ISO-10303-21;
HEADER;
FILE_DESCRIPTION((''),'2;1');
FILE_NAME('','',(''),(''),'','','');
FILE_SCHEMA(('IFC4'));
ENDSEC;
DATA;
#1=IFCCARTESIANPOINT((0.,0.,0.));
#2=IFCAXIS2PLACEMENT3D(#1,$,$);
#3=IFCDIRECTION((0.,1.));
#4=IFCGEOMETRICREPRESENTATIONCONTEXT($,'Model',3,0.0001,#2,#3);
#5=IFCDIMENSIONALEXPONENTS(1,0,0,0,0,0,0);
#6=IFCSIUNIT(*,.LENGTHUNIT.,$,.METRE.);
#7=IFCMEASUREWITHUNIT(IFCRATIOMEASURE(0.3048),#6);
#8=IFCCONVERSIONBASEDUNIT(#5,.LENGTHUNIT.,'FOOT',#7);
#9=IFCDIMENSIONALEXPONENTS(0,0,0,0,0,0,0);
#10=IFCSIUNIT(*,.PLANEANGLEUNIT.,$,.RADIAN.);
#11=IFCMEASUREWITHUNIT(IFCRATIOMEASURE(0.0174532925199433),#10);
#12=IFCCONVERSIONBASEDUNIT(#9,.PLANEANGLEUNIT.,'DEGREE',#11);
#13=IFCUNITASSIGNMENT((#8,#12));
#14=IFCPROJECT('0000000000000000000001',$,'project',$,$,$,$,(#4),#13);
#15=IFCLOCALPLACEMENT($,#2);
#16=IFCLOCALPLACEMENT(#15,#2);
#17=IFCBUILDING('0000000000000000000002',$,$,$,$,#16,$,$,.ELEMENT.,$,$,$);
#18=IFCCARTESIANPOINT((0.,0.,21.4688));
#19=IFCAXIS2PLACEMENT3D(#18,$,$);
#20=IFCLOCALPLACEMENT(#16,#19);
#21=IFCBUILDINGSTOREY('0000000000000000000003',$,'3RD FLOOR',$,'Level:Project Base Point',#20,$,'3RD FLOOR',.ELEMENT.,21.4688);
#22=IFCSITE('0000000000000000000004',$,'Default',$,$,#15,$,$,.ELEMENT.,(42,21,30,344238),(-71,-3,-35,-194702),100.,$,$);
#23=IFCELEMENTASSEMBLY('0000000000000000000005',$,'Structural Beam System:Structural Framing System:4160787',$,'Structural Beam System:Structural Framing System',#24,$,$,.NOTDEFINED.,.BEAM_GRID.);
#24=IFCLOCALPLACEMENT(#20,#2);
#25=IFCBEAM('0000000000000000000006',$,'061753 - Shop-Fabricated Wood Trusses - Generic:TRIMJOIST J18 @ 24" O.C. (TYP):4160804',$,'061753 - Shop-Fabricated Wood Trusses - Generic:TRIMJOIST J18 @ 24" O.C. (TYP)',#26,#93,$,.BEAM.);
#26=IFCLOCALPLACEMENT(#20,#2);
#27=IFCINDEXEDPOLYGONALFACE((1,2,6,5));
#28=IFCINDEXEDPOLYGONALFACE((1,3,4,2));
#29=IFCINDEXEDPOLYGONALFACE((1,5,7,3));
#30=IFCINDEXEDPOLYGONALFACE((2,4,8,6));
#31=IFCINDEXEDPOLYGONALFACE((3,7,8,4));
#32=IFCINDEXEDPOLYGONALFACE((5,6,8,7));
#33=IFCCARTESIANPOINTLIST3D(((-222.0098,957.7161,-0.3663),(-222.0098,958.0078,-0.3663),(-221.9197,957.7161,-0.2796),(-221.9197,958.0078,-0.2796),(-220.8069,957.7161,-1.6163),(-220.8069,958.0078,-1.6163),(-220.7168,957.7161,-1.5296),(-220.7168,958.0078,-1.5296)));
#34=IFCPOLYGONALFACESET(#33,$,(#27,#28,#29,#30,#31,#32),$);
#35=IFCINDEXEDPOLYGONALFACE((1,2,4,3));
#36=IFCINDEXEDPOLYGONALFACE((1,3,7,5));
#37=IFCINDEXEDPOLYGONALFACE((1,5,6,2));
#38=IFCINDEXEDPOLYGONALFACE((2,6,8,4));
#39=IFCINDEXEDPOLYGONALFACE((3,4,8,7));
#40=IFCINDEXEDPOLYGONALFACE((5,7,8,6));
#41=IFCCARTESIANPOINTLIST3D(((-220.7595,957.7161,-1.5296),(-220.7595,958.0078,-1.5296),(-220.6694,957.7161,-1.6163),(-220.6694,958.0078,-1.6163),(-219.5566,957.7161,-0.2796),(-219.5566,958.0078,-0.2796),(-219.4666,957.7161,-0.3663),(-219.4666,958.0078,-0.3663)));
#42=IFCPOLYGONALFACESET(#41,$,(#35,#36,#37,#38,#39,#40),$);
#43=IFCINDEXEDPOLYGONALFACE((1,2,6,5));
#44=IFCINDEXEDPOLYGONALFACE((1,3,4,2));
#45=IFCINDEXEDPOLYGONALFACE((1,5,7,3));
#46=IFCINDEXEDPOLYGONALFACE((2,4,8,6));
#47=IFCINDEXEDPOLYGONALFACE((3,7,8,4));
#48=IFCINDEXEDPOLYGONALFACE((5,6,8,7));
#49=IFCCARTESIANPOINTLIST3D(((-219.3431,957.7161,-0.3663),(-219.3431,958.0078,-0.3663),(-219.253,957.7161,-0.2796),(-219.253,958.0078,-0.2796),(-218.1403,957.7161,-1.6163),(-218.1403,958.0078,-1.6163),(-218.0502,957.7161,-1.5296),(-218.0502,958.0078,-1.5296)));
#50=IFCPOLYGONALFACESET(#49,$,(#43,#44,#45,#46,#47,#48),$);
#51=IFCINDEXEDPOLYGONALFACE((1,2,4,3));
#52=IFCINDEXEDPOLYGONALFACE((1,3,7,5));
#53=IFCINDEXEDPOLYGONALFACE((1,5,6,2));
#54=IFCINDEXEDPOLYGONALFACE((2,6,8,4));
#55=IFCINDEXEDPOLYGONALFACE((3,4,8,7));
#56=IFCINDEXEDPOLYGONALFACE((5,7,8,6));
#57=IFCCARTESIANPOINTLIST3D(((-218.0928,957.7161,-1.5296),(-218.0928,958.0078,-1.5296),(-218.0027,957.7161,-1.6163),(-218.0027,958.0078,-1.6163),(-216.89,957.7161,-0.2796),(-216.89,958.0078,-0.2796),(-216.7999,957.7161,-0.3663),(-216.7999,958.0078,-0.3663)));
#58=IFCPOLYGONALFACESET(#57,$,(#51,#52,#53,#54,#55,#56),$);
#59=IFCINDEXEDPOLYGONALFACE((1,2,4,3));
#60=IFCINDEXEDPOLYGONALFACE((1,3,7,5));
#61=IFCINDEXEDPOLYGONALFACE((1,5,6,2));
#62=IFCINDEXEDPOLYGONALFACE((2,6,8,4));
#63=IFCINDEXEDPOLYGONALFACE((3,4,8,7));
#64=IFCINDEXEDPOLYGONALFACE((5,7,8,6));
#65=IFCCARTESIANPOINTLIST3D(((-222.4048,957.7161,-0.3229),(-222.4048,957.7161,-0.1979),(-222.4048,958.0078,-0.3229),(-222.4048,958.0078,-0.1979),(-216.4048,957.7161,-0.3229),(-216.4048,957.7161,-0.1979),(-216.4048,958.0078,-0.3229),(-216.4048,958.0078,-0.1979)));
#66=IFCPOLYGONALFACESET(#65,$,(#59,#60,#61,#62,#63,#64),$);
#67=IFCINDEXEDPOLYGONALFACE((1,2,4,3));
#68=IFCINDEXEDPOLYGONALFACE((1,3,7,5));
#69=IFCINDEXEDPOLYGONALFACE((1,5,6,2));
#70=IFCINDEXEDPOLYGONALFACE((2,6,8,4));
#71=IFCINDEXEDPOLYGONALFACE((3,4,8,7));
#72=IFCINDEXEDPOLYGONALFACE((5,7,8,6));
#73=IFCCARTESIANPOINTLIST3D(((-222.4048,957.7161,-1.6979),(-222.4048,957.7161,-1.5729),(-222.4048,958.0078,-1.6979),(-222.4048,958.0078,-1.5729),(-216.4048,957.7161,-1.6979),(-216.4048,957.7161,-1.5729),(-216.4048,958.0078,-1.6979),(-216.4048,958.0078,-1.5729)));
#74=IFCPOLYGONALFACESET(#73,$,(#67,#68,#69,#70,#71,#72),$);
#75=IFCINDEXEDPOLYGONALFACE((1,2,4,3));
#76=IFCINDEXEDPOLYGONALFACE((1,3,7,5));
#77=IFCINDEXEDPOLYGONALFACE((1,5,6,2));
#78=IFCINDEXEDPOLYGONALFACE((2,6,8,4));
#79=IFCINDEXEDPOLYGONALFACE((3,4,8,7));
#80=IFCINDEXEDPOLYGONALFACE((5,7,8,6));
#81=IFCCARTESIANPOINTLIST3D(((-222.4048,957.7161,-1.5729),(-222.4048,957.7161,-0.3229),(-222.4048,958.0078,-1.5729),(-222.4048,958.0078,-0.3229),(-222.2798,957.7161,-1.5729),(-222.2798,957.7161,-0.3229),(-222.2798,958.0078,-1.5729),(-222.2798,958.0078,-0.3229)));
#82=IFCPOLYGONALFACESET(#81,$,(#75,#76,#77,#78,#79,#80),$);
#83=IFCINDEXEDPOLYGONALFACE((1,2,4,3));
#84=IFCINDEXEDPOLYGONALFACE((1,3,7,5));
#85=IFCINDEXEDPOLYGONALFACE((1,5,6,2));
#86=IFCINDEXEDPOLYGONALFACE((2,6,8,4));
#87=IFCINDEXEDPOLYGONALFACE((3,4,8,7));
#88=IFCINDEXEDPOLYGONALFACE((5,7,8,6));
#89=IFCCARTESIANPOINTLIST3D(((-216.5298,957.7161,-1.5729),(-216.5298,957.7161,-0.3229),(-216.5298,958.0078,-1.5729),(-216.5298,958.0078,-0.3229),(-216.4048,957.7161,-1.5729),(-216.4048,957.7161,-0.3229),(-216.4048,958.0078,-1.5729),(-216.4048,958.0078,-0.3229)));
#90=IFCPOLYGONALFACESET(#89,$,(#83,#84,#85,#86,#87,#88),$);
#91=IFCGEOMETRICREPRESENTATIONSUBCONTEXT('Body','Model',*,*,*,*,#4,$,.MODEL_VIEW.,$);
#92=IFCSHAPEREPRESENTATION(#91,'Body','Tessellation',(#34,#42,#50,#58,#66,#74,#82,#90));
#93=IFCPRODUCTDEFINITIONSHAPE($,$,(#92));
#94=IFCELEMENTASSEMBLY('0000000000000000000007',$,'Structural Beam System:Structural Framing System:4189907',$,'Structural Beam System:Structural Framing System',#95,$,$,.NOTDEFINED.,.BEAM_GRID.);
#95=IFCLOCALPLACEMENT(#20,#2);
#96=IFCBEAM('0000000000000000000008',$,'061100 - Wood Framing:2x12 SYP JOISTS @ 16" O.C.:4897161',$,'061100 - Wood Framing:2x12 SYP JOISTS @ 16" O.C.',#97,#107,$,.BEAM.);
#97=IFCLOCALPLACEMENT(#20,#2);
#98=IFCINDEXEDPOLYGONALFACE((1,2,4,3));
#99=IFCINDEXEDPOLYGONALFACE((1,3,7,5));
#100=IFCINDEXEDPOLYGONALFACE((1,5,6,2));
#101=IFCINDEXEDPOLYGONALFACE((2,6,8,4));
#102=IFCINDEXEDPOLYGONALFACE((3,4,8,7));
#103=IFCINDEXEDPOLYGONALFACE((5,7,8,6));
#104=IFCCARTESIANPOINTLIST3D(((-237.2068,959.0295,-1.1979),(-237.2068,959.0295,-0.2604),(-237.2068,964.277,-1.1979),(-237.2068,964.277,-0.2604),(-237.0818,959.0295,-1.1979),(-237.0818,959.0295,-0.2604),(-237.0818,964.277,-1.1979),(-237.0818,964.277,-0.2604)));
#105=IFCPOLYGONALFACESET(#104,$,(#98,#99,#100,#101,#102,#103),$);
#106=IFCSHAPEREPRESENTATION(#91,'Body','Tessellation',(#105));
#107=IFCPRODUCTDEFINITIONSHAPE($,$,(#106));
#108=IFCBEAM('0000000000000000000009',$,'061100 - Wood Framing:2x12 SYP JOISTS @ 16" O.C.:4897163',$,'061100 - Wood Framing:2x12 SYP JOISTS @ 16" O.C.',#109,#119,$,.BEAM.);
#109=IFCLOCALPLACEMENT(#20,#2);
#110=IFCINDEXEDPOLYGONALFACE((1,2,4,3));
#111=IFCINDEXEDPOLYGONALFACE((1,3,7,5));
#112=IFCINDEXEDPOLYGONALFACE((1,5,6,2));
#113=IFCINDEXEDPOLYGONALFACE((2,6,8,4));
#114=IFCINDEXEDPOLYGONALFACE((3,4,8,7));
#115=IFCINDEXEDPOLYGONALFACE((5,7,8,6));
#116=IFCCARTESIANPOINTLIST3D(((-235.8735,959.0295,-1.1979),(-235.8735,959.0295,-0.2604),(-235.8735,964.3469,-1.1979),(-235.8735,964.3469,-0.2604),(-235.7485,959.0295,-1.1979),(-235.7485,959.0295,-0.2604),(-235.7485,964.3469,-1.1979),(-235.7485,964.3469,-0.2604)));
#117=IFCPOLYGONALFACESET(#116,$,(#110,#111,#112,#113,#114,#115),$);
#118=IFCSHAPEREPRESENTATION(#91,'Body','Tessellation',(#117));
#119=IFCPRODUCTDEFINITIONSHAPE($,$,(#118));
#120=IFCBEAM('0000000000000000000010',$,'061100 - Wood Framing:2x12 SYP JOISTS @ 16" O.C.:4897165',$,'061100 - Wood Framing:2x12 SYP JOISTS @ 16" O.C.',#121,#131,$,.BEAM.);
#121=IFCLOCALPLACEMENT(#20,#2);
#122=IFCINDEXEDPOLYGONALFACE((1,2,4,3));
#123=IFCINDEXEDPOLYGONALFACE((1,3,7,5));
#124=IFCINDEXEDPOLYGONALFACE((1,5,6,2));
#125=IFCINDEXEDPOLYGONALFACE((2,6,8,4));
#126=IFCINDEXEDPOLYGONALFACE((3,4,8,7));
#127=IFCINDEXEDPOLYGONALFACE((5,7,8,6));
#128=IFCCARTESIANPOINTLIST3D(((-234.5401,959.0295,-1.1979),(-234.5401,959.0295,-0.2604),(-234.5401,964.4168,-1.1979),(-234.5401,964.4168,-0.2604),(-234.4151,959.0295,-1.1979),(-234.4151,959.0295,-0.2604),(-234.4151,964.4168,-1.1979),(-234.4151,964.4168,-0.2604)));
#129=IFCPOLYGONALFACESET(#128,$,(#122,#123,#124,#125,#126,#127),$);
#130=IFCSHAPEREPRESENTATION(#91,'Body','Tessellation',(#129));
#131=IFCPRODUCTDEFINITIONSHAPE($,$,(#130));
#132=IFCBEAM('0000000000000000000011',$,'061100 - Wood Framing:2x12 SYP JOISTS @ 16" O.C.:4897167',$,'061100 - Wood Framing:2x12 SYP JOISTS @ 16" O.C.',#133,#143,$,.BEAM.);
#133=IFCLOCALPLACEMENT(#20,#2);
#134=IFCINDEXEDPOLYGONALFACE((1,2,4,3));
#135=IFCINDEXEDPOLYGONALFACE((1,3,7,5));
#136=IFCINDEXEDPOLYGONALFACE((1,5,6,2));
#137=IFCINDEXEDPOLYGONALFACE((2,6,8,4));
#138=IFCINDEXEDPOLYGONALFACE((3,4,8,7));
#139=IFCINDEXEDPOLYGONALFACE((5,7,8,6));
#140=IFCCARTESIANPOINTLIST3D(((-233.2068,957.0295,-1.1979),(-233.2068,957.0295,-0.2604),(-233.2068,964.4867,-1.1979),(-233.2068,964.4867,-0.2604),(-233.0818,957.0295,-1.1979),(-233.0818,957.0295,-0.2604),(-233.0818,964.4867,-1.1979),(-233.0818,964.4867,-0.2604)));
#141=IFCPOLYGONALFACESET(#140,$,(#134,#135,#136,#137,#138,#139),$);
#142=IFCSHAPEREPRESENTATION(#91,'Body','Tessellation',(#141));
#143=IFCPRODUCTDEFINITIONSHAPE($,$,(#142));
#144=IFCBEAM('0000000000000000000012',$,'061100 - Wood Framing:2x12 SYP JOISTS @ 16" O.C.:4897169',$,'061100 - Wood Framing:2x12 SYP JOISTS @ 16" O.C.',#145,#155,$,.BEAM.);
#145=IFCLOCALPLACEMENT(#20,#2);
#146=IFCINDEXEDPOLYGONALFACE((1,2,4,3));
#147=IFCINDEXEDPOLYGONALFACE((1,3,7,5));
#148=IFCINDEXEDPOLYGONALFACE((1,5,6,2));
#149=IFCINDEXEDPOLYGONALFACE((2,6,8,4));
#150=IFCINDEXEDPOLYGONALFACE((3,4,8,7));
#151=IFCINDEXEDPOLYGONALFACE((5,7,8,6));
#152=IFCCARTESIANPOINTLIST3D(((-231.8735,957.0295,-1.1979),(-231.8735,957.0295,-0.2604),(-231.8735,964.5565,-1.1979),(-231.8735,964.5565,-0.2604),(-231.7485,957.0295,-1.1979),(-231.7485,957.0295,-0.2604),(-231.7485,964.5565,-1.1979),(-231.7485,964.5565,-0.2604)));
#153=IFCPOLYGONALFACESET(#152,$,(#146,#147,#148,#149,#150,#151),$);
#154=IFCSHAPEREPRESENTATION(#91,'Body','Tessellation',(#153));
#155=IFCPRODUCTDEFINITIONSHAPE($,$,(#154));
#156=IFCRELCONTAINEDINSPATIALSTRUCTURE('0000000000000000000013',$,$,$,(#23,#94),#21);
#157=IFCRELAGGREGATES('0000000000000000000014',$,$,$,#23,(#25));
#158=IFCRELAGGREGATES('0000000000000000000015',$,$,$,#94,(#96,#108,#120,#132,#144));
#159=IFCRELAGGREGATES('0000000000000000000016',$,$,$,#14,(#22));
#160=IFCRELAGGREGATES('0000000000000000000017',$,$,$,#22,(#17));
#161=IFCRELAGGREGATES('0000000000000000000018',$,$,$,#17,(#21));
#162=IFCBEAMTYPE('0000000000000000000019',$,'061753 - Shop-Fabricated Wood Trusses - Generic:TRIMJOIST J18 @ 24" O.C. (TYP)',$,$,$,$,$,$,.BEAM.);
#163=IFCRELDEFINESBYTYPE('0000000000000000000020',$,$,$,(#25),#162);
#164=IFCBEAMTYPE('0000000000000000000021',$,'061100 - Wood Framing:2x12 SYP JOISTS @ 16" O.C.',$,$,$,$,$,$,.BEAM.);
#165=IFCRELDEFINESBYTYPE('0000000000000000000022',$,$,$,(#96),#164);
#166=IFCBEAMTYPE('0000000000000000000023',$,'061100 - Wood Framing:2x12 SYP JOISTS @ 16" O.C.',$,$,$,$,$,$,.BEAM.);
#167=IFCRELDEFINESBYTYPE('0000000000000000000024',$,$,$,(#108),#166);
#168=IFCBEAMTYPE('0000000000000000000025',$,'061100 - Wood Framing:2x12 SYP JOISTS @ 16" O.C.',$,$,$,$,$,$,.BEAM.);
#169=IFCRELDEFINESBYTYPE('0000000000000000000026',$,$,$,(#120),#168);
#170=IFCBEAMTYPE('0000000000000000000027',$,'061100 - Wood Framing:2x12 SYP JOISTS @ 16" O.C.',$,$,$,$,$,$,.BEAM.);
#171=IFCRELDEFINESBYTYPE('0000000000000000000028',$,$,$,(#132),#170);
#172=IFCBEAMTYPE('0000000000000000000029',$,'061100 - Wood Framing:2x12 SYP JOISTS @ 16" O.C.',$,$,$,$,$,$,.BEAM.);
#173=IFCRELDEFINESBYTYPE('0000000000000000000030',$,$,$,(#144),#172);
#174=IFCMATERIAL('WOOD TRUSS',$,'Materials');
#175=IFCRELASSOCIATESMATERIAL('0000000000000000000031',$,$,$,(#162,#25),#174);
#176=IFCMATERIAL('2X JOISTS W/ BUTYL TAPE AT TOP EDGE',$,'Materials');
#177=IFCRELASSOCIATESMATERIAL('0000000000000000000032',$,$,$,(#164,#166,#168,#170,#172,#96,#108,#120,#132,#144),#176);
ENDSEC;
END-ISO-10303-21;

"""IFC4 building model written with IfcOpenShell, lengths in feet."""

from ifc_helpers import new_model, entity, si_unit, converted_unit, direction, frame, frame_2d, origin, origin_2d_with_axis, place, context, subcontext, project, spatial, rectangle, extrude, source, transform, mapped, material, material_profile, profile_set, profile_usage, type_object, type_shapes, element, aggregate, save


model = new_model("IFC4")

# Units and contexts
model_context = context("Model", 3, precision=0.0001, world=origin(), true_north=direction((0.0, 1.0)))
body_context = subcontext(model_context, "Body", "Model", "MODEL_VIEW")
ifc_project = project(units=[converted_unit("LENGTHUNIT", "FOOT", entity("IfcRatioMeasure", 0.3048), si_unit("LENGTHUNIT", "METRE"), dimensions=[1, 0, 0, 0, 0, 0, 0]), converted_unit("PLANEANGLEUNIT", "DEGREE", entity("IfcRatioMeasure", 0.0174532925199433), si_unit("PLANEANGLEUNIT", "RADIAN"), dimensions=[0, 0, 0, 0, 0, 0, 0])], contexts=[model_context])

# Site, building, storey
site_placement = place(None, origin())
site = spatial("IfcSite", under=ifc_project, at=site_placement, Name="Default", CompositionType="ELEMENT", RefLatitude=(42, 21, 30, 344238), RefLongitude=(-71, -3, -35, -194702), RefElevation=100.0)
building_placement = place(site_placement, origin())
building = spatial("IfcBuilding", under=site, at=building_placement, CompositionType="ELEMENT")
storey_placement = place(building_placement, frame((0.0, 0.0, 21.4688)))
storey = spatial("IfcBuildingStorey", under=building, at=storey_placement, Name="3RD FLOOR", ObjectType="Level:Project Base Point", LongName="3RD FLOOR", CompositionType="ELEMENT", Elevation=21.4688)

# Element assemblies, beams
ifc_material_1 = material(Name="WOOD TRUSS", Category="Materials")
ifc_material_profile_1 = material_profile(ifc_material_1, rectangle(XDim=1.7347, YDim=0.125, at=frame_2d((0.0, 0.0), x_axis=(1.0, 0.0))), Name="TRIMJOIST J18 @ 24\" O.C. (TYP)")
ifc_material_profile_2 = material_profile(ifc_material_1, rectangle(XDim=1.7347, YDim=0.125, at=frame_2d((0.0, 0.0), x_axis=(1.0, 0.0))), Name="TRIMJOIST J18 @ 24\" O.C. (TYP)")
ifc_material_profile_3 = material_profile(ifc_material_1, rectangle(XDim=1.7347, YDim=0.125, at=frame_2d((0.0, 0.0), x_axis=(1.0, 0.0))), Name="TRIMJOIST J18 @ 24\" O.C. (TYP)")
ifc_material_profile_4 = material_profile(ifc_material_1, rectangle(XDim=1.7347, YDim=0.125, at=frame_2d((0.0, 0.0), x_axis=(1.0, 0.0))), Name="TRIMJOIST J18 @ 24\" O.C. (TYP)")
ifc_material_profile_5 = material_profile(ifc_material_1, rectangle(XDim=1.7347, YDim=0.125, at=frame_2d((0.0, 0.0), x_axis=(1.0, 0.0))), Name="TRIMJOIST J18 @ 24\" O.C. (TYP)")
ifc_material_profile_6 = material_profile(ifc_material_1, rectangle(XDim=1.7347, YDim=0.125, at=frame_2d((0.0, 0.0), x_axis=(1.0, 0.0))), Name="TRIMJOIST J18 @ 24\" O.C. (TYP)")
ifc_material_profile_7 = material_profile(ifc_material_1, rectangle(XDim=1.7347, YDim=0.125, at=frame_2d((0.0, 0.0), x_axis=(1.0, 0.0))), Name="TRIMJOIST J18 @ 24\" O.C. (TYP)")
ifc_material_profile_8 = material_profile(ifc_material_1, rectangle(XDim=1.7347, YDim=0.125, at=frame_2d((0.0, 0.0), x_axis=(1.0, 0.0))), Name="TRIMJOIST J18 @ 24\" O.C. (TYP)")
ifc_material_profile_9 = material_profile(ifc_material_1, rectangle(XDim=1.7347, YDim=0.125, at=frame_2d((0.0, 0.0), x_axis=(1.0, 0.0))), Name="TRIMJOIST J18 @ 24\" O.C. (TYP)")
ifc_material_profile_10 = material_profile(ifc_material_1, rectangle(XDim=1.7347, YDim=0.125, at=origin_2d_with_axis()), Name="TRIMJOIST J18 @ 24\" O.C. (TYP)")
ifc_material_profile_11 = material_profile(ifc_material_1, rectangle(XDim=0.125, YDim=0.2917, at=origin_2d_with_axis()), Name="TRIMJOIST J18 @ 24\" O.C. (TYP)")
ifc_material_profile_12 = material_profile(ifc_material_1, rectangle(XDim=0.125, YDim=0.2917, at=origin_2d_with_axis()), Name="TRIMJOIST J18 @ 24\" O.C. (TYP)")
ifc_material_profile_13 = material_profile(ifc_material_1, rectangle(XDim=1.25, YDim=0.2917, at=origin_2d_with_axis()), Name="TRIMJOIST J18 @ 24\" O.C. (TYP)")
ifc_material_profile_14 = material_profile(ifc_material_1, rectangle(XDim=1.25, YDim=0.2917, at=origin_2d_with_axis()), Name="TRIMJOIST J18 @ 24\" O.C. (TYP)")
ifc_profile_set_1 = profile_set([ifc_material_profile_1, ifc_material_profile_2, ifc_material_profile_3, ifc_material_profile_4, ifc_material_profile_5, ifc_material_profile_6, ifc_material_profile_7, ifc_material_profile_8, ifc_material_profile_9, ifc_material_profile_10, ifc_material_profile_11, ifc_material_profile_12, ifc_material_profile_13, ifc_material_profile_14], Name="TRIMJOIST J18 @ 24\" O.C. (TYP)")
assembly_1_placement = place(storey_placement, origin())
assembly_1 = element("IfcElementAssembly", 1, at=assembly_1_placement, inside=storey, Name="Structural Beam System:Structural Framing System:4160787", ObjectType="Structural Beam System:Structural Framing System", AssemblyPlace="NOTDEFINED", PredefinedType="BEAM_GRID")
ifc_profile_usage_1 = profile_usage(ifc_profile_set_1, cardinal=8)
beam_type_1 = type_object("IfcBeamType", Name="061753 - Shop-Fabricated Wood Trusses - Generic:TRIMJOIST J18 @ 24\" O.C. (TYP)", PredefinedType="BEAM", material=ifc_profile_set_1)
shared_shape_1 = source(origin(), body_context, "Body", "SweptSolid", [
    extrude(rectangle(XDim=1.7347, YDim=0.125, at=frame_2d((0.0, 0.0), x_axis=(1.0, 0.0))), frame((1.9585, -0.1458, 0.0), z_axis=(0.0, 1.0, 0.0), x_axis=(0.693383, 0.0, 0.720569)), (0.0, 0.0, 1.0), 0.2917),
    extrude(rectangle(XDim=1.7347, YDim=0.125, at=frame_2d((0.0, 0.0), x_axis=(1.0, 0.0))), frame((0.7082, -0.1458, 0.0), z_axis=(0.0, 1.0, 0.0), x_axis=(0.693383, 0.0, -0.720569)), (0.0, 0.0, 1.0), 0.2917),
    extrude(rectangle(XDim=1.7347, YDim=0.125, at=frame_2d((0.0, 0.0), x_axis=(1.0, 0.0))), frame((-0.7082, -0.1458, 0.0), z_axis=(0.0, 1.0, 0.0), x_axis=(0.693383, 0.0, 0.720569)), (0.0, 0.0, 1.0), 0.2917),
    extrude(rectangle(XDim=1.7347, YDim=0.125, at=frame_2d((0.0, 0.0), x_axis=(1.0, 0.0))), frame((-1.9585, -0.1458, 0.0), z_axis=(0.0, 1.0, 0.0), x_axis=(0.693383, 0.0, -0.720569)), (0.0, 0.0, 1.0), 0.2917),
    extrude(rectangle(XDim=0.125, YDim=0.2917, at=origin_2d_with_axis()), frame((-3.0, 0.0, 0.6875), z_axis=(1.0, 0.0, 0.0), x_axis=(0.0, 0.0, -1.0)), (0.0, 0.0, 1.0), 6.0),
    extrude(rectangle(XDim=0.125, YDim=0.2917, at=origin_2d_with_axis()), frame((-3.0, 0.0, -0.6875), z_axis=(1.0, 0.0, 0.0), x_axis=(0.0, 0.0, -1.0)), (0.0, 0.0, 1.0), 6.0),
    extrude(rectangle(XDim=1.25, YDim=0.2917, at=origin_2d_with_axis()), frame((2.875, 0.0, 0.0), z_axis=(1.0, 0.0, 0.0), x_axis=(0.0, 0.0, -1.0)), (0.0, 0.0, 1.0), 0.125),
    extrude(rectangle(XDim=1.25, YDim=0.2917, at=origin_2d_with_axis()), frame((-3.0, 0.0, 0.0), z_axis=(1.0, 0.0, 0.0), x_axis=(0.0, 0.0, -1.0)), (0.0, 0.0, 1.0), 0.125),
])
type_shapes(beam_type_1, [shared_shape_1])
beam_1_placement = place(assembly_1_placement, frame((-219.4048, 957.8619, -0.9479), z_axis=(0.0, 0.0, 1.0), x_axis=(-1.0, 0.0, 0.0)))
beam_1 = element("IfcBeam", 2, at=beam_1_placement, type_object=beam_type_1, material=ifc_profile_usage_1, Name="061753 - Shop-Fabricated Wood Trusses - Generic:TRIMJOIST J18 @ 24\" O.C. (TYP):4160804", ObjectType="061753 - Shop-Fabricated Wood Trusses - Generic:TRIMJOIST J18 @ 24\" O.C. (TYP)", PredefinedType="BEAM", context=body_context, shape_type="MappedRepresentation", body=[
    mapped(shared_shape_1, transform((0.0, 0.0, 0.0), scale=1.0)),
])
aggregate(assembly_1, [beam_1])
assembly_2_placement = place(storey_placement, origin())
assembly_2 = element("IfcElementAssembly", 3, at=assembly_2_placement, inside=storey, Name="Structural Beam System:Structural Framing System:4189907", ObjectType="Structural Beam System:Structural Framing System", AssemblyPlace="NOTDEFINED", PredefinedType="BEAM_GRID")
ifc_material_2 = material(Name="2X JOISTS W/ BUTYL TAPE AT TOP EDGE", Category="Materials")
ifc_material_profile_15 = material_profile(ifc_material_2, rectangle(XDim=0.9375, YDim=0.125, at=origin_2d_with_axis()), Name="2x12 SYP JOISTS @ 16\" O.C.")
ifc_profile_set_2 = profile_set([ifc_material_profile_15], Name="2x12 SYP JOISTS @ 16\" O.C.")
ifc_profile_usage_2 = profile_usage(ifc_profile_set_2, cardinal=8)
beam_type_2 = type_object("IfcBeamType", Name="061100 - Wood Framing:2x12 SYP JOISTS @ 16\" O.C.", PredefinedType="BEAM", material=ifc_profile_set_2)
shared_shape_2 = source(origin(), body_context, "Body", "SweptSolid", [
    extrude(rectangle(XDim=0.9375, YDim=0.125, at=origin_2d_with_axis()), frame((-2.6238, 0.0, 0.0), z_axis=(1.0, 0.0, 0.0), x_axis=(0.0, 0.0, -1.0)), (0.0, 0.0, 1.0), 5.2475),
])
type_shapes(beam_type_2, [shared_shape_2])
beam_2_placement = place(assembly_2_placement, frame((-237.1443, 961.6533, -0.7292), z_axis=(0.0, 0.0, 1.0), x_axis=(0.0, 1.0, 0.0)))
beam_2 = element("IfcBeam", 4, at=beam_2_placement, type_object=beam_type_2, material=ifc_profile_usage_2, Name="061100 - Wood Framing:2x12 SYP JOISTS @ 16\" O.C.:4897161", ObjectType="061100 - Wood Framing:2x12 SYP JOISTS @ 16\" O.C.", PredefinedType="BEAM", context=body_context, shape_type="MappedRepresentation", body=[
    mapped(shared_shape_2, transform((0.0, 0.0, 0.0), scale=1.0)),
])
ifc_profile_usage_3 = profile_usage(ifc_profile_set_2, cardinal=8)
beam_type_3 = type_object("IfcBeamType", Name="061100 - Wood Framing:2x12 SYP JOISTS @ 16\" O.C.", PredefinedType="BEAM", material=ifc_profile_set_2)
shared_shape_3 = source(origin(), body_context, "Body", "SweptSolid", [
    extrude(rectangle(XDim=0.9375, YDim=0.125, at=origin_2d_with_axis()), frame((-2.6587, 0.0, 0.0), z_axis=(1.0, 0.0, 0.0), x_axis=(0.0, 0.0, -1.0)), (0.0, 0.0, 1.0), 5.3174),
])
type_shapes(beam_type_3, [shared_shape_3])
beam_3_placement = place(assembly_2_placement, frame((-235.811, 961.6882, -0.7292), z_axis=(0.0, 0.0, 1.0), x_axis=(0.0, 1.0, 0.0)))
beam_3 = element("IfcBeam", 5, at=beam_3_placement, type_object=beam_type_3, material=ifc_profile_usage_3, Name="061100 - Wood Framing:2x12 SYP JOISTS @ 16\" O.C.:4897163", ObjectType="061100 - Wood Framing:2x12 SYP JOISTS @ 16\" O.C.", PredefinedType="BEAM", context=body_context, shape_type="MappedRepresentation", body=[
    mapped(shared_shape_3, transform((0.0, 0.0, 0.0), scale=1.0)),
])
ifc_profile_usage_4 = profile_usage(ifc_profile_set_2, cardinal=8)
beam_type_4 = type_object("IfcBeamType", Name="061100 - Wood Framing:2x12 SYP JOISTS @ 16\" O.C.", PredefinedType="BEAM", material=ifc_profile_set_2)
shared_shape_4 = source(origin(), body_context, "Body", "SweptSolid", [
    extrude(rectangle(XDim=0.9375, YDim=0.125, at=origin_2d_with_axis()), frame((-2.6936, 0.0, 0.0), z_axis=(1.0, 0.0, 0.0), x_axis=(0.0, 0.0, -1.0)), (0.0, 0.0, 1.0), 5.3873),
])
type_shapes(beam_type_4, [shared_shape_4])
beam_4_placement = place(assembly_2_placement, frame((-234.4776, 961.7231, -0.7292), z_axis=(0.0, 0.0, 1.0), x_axis=(0.0, 1.0, 0.0)))
beam_4 = element("IfcBeam", 6, at=beam_4_placement, type_object=beam_type_4, material=ifc_profile_usage_4, Name="061100 - Wood Framing:2x12 SYP JOISTS @ 16\" O.C.:4897165", ObjectType="061100 - Wood Framing:2x12 SYP JOISTS @ 16\" O.C.", PredefinedType="BEAM", context=body_context, shape_type="MappedRepresentation", body=[
    mapped(shared_shape_4, transform((0.0, 0.0, 0.0), scale=1.0)),
])
ifc_profile_usage_5 = profile_usage(ifc_profile_set_2, cardinal=8)
beam_type_5 = type_object("IfcBeamType", Name="061100 - Wood Framing:2x12 SYP JOISTS @ 16\" O.C.", PredefinedType="BEAM", material=ifc_profile_set_2)
shared_shape_5 = source(origin(), body_context, "Body", "SweptSolid", [
    extrude(rectangle(XDim=0.9375, YDim=0.125, at=origin_2d_with_axis()), frame((-3.7286, 0.0, 0.0), z_axis=(1.0, 0.0, 0.0), x_axis=(0.0, 0.0, -1.0)), (0.0, 0.0, 1.0), 7.4571),
])
type_shapes(beam_type_5, [shared_shape_5])
beam_5_placement = place(assembly_2_placement, frame((-233.1443, 960.7581, -0.7292), z_axis=(0.0, 0.0, 1.0), x_axis=(0.0, 1.0, 0.0)))
beam_5 = element("IfcBeam", 7, at=beam_5_placement, type_object=beam_type_5, material=ifc_profile_usage_5, Name="061100 - Wood Framing:2x12 SYP JOISTS @ 16\" O.C.:4897167", ObjectType="061100 - Wood Framing:2x12 SYP JOISTS @ 16\" O.C.", PredefinedType="BEAM", context=body_context, shape_type="MappedRepresentation", body=[
    mapped(shared_shape_5, transform((0.0, 0.0, 0.0), scale=1.0)),
])
ifc_profile_usage_6 = profile_usage(ifc_profile_set_2, cardinal=8)
beam_type_6 = type_object("IfcBeamType", Name="061100 - Wood Framing:2x12 SYP JOISTS @ 16\" O.C.", PredefinedType="BEAM", material=ifc_profile_set_2)
shared_shape_6 = source(origin(), body_context, "Body", "SweptSolid", [
    extrude(rectangle(XDim=0.9375, YDim=0.125, at=origin_2d_with_axis()), frame((-3.7635, 0.0, 0.0), z_axis=(1.0, 0.0, 0.0), x_axis=(0.0, 0.0, -1.0)), (0.0, 0.0, 1.0), 7.527),
])
type_shapes(beam_type_6, [shared_shape_6])
beam_6_placement = place(assembly_2_placement, frame((-231.811, 960.793, -0.7292), z_axis=(0.0, 0.0, 1.0), x_axis=(0.0, 1.0, 0.0)))
beam_6 = element("IfcBeam", 8, at=beam_6_placement, type_object=beam_type_6, material=ifc_profile_usage_6, Name="061100 - Wood Framing:2x12 SYP JOISTS @ 16\" O.C.:4897169", ObjectType="061100 - Wood Framing:2x12 SYP JOISTS @ 16\" O.C.", PredefinedType="BEAM", context=body_context, shape_type="MappedRepresentation", body=[
    mapped(shared_shape_6, transform((0.0, 0.0, 0.0), scale=1.0)),
])
aggregate(assembly_2, [beam_2, beam_3, beam_4, beam_5, beam_6])

save(model, "model.ifc")
